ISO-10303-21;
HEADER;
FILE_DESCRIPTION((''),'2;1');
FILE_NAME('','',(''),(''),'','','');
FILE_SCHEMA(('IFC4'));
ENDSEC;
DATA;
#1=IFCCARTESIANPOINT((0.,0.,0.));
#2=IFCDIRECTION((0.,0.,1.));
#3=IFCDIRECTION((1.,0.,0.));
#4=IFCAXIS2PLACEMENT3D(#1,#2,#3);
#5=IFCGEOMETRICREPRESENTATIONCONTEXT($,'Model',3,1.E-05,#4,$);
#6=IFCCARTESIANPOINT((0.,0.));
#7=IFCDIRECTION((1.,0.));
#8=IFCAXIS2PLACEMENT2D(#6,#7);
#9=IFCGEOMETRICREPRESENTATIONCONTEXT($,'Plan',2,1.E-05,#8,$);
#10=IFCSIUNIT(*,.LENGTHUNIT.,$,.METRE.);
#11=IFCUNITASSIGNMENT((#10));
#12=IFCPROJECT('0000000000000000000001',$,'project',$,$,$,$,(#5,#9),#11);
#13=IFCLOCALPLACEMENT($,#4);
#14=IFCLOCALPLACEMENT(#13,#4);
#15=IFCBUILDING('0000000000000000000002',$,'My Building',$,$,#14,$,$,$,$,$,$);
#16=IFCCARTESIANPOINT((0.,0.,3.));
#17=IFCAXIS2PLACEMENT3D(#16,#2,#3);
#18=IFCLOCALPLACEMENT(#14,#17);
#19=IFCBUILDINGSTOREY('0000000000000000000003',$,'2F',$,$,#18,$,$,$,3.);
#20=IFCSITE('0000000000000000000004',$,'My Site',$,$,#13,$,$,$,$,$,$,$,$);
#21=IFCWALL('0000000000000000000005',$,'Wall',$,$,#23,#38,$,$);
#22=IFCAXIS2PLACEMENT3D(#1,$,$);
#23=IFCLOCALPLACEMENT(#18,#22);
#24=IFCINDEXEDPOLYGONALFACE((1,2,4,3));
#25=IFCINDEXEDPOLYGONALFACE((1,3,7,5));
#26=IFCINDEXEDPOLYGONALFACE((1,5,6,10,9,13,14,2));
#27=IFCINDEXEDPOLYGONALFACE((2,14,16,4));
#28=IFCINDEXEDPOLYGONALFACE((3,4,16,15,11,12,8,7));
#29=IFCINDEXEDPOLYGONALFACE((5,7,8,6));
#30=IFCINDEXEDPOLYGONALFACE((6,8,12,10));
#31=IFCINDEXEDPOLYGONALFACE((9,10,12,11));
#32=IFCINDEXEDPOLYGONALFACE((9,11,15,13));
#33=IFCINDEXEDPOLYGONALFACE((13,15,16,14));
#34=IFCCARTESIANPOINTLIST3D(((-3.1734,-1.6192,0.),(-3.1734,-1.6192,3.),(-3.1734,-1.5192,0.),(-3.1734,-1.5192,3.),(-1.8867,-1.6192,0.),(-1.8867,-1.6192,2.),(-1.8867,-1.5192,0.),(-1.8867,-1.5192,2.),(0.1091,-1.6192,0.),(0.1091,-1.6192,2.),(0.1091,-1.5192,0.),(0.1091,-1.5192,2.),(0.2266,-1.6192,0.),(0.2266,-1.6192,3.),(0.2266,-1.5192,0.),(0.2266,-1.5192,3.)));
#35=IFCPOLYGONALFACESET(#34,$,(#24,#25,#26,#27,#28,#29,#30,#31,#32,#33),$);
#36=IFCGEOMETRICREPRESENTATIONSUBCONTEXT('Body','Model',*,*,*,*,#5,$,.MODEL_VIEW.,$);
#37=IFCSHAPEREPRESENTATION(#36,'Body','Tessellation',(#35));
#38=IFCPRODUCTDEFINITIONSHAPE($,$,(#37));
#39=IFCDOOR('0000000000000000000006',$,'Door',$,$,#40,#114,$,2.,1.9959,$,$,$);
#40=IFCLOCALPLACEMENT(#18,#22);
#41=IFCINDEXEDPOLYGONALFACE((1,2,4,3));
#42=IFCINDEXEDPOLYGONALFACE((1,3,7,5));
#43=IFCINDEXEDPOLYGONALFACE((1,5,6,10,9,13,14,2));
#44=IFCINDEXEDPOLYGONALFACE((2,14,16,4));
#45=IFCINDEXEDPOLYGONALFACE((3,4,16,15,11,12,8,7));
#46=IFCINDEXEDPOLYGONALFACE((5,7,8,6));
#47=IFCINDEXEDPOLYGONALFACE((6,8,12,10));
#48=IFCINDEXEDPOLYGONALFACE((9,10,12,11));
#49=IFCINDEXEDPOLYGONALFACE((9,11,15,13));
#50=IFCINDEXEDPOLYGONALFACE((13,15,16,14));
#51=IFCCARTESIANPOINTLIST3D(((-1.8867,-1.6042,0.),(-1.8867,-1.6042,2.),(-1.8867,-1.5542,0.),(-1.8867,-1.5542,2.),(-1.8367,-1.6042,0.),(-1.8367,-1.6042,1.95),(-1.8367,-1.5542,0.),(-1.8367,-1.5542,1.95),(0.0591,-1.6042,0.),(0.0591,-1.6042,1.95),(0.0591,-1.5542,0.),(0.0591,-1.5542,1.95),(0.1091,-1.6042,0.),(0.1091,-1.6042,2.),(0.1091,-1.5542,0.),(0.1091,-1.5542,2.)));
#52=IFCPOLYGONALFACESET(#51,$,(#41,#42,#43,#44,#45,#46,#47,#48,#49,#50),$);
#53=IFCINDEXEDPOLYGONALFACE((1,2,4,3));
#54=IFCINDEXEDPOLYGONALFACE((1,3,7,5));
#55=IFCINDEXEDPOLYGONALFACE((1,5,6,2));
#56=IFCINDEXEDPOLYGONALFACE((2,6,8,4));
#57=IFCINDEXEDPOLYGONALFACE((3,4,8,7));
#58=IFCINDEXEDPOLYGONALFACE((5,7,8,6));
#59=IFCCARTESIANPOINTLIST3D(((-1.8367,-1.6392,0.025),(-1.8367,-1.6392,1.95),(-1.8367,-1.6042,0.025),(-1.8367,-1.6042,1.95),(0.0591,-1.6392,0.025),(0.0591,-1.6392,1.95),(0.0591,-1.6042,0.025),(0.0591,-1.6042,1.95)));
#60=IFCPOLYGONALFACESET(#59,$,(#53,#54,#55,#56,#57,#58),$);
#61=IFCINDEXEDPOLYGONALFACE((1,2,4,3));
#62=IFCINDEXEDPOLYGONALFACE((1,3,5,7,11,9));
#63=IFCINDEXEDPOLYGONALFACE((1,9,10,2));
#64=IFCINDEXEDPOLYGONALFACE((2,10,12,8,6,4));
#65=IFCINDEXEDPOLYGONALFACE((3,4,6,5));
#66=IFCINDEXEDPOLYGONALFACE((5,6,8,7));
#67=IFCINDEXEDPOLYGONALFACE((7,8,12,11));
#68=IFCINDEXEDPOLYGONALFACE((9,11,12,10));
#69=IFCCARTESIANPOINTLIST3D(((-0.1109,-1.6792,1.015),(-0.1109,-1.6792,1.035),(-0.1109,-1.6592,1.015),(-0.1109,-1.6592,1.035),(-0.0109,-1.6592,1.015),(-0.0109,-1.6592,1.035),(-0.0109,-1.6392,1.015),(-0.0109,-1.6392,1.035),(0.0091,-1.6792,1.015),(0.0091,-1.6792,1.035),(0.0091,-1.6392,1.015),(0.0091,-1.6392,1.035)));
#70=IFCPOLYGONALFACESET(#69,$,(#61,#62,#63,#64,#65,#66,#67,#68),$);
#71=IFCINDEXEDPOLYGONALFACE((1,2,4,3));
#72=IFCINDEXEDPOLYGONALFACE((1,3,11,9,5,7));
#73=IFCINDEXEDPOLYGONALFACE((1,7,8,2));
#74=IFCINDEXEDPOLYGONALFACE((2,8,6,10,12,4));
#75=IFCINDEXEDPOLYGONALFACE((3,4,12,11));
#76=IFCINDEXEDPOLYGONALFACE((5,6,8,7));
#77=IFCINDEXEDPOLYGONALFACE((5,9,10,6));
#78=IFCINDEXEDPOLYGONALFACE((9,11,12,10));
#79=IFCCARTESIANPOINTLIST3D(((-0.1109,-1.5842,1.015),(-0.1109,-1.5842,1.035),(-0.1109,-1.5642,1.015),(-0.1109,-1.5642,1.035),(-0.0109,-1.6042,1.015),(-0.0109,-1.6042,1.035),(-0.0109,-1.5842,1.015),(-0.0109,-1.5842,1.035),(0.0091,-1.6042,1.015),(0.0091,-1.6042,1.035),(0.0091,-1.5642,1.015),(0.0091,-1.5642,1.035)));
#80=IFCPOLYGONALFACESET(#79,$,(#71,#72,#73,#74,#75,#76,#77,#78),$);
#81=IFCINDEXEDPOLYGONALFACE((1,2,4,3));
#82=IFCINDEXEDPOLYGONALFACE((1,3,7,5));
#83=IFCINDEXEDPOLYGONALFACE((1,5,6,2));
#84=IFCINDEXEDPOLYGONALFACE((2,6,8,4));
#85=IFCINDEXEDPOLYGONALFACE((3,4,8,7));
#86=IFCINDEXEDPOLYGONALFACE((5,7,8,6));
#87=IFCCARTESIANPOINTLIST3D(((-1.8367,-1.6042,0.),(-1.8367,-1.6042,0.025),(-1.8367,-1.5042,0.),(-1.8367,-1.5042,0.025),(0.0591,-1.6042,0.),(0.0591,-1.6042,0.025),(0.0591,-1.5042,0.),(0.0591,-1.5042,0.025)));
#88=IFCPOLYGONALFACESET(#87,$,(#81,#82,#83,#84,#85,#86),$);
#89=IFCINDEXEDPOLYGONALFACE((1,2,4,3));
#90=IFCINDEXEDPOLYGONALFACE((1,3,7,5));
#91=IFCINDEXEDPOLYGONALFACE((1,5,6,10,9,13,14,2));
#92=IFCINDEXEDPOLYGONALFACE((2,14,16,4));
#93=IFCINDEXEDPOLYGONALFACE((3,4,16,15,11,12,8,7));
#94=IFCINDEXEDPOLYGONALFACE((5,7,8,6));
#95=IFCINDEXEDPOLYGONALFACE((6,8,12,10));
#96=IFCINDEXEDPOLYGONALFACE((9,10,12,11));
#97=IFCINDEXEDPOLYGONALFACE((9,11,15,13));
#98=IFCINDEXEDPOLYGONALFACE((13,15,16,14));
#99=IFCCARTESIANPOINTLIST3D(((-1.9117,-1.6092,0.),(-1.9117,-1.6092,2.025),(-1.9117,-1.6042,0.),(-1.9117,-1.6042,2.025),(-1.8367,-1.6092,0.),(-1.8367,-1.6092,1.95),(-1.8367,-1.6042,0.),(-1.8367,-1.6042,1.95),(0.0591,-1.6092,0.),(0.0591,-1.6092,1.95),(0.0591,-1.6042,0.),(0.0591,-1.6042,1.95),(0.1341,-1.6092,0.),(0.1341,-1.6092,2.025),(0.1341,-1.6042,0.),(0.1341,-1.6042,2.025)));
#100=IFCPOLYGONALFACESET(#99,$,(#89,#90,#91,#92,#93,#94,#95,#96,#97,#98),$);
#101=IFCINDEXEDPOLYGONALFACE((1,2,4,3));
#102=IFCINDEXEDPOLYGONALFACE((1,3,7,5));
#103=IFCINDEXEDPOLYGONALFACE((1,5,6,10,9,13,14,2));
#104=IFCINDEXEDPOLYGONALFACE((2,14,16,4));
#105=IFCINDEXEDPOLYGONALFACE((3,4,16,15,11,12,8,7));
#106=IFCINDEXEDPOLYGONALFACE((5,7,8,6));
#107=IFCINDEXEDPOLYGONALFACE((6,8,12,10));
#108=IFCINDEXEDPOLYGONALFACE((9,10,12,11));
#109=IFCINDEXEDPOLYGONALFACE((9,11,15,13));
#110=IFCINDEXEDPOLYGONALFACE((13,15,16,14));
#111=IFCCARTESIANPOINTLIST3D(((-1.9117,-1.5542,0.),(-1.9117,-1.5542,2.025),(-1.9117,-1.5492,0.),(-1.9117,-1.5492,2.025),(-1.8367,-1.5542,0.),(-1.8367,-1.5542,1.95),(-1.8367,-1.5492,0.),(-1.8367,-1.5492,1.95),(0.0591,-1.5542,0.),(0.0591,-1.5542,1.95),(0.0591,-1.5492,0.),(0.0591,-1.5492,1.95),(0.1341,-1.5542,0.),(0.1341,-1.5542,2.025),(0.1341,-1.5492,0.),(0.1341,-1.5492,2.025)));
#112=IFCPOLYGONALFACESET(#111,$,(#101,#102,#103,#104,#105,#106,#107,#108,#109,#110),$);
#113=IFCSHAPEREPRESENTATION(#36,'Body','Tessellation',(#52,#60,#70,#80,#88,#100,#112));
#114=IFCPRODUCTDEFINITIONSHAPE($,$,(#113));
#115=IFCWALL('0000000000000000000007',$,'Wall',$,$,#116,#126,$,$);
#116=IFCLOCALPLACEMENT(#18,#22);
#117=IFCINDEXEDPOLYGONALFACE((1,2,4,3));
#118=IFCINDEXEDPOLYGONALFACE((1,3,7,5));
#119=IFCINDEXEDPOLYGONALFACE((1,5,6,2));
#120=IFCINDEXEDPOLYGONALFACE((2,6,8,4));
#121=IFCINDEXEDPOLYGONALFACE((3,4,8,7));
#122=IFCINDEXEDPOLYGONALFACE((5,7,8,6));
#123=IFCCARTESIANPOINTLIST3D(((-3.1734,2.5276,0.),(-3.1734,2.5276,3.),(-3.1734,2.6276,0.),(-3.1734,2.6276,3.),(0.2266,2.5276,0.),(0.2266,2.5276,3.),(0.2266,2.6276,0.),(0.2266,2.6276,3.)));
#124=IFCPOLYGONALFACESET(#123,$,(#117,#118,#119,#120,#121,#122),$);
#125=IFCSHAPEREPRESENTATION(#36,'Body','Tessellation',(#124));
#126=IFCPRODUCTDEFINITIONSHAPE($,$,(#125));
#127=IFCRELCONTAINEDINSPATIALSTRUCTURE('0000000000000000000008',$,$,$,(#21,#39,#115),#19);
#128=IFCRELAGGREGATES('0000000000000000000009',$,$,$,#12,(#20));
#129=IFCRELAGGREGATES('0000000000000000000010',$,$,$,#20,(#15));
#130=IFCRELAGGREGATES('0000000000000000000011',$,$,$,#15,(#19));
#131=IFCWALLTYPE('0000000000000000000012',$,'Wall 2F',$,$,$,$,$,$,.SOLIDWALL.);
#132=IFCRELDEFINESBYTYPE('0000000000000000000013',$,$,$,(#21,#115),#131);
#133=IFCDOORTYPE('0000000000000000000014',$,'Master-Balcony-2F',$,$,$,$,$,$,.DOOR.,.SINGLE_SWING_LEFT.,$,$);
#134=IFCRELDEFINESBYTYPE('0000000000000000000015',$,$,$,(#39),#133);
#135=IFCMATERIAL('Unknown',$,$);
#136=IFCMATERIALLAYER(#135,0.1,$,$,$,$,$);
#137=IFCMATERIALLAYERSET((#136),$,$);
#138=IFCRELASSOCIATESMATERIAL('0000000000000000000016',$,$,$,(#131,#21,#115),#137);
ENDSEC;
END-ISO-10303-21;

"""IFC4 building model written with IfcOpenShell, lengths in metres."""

from ifc_helpers import new_model, entity, si_unit, frame, origin_with_axes, origin_2d_with_axis, place, context, subcontext, project, spatial, polyline, line, indexed_curve, outline, extrude, shape, source, transform, mapped, material, layer, layer_set, layer_usage, type_object, type_shapes, element, fill, save


model = new_model("IFC4")

# Units and contexts
model_context = context("Model", 3, precision=1e-05, world=origin_with_axes())
plan_context = context("Plan", 2, precision=1e-05, world=origin_2d_with_axis())
body_context_1 = subcontext(model_context, "Body", "Model", "MODEL_VIEW")
body_context_2 = subcontext(plan_context, "Body", "Plan", "PLAN_VIEW")
ifc_project = project(units=[si_unit("LENGTHUNIT", "METRE")], contexts=[model_context, plan_context])

# Site, building, storey
site_placement = place(None, origin_with_axes())
site = spatial("IfcSite", under=ifc_project, at=site_placement, Name="My Site")
building_placement = place(site_placement, origin_with_axes())
building = spatial("IfcBuilding", under=site, at=building_placement, Name="My Building")
storey_placement = place(building_placement, frame((0.0, 0.0, 3.0), z_axis=(0.0, 0.0, 1.0), x_axis=(1.0, 0.0, 0.0)))
storey = spatial("IfcBuildingStorey", under=building, at=storey_placement, Name="2F", Elevation=3.0)

# Shared definitions
ifc_material = material(Name="Unknown")

# Shared definitions
ifc_layer_1 = layer(ifc_material, 0.1)
ifc_layer_set_1 = layer_set([ifc_layer_1])
wall_type = type_object("IfcWallType", Name="Wall 2F", PredefinedType="SOLIDWALL", material=ifc_layer_set_1)

# Wall, opening, door
ifc_layer_usage_1 = layer_usage(ifc_layer_set_1, "AXIS2", "POSITIVE", 0.0)
wall_1_placement = place(storey_placement, frame((-3.1734, -1.6192, 0.0), z_axis=(0.0, 0.0, 1.0), x_axis=(1.0, 0.0, 0.0)))
wall_1 = element("IfcWall", 1, at=wall_1_placement, inside=storey, type_object=wall_type, material=ifc_layer_usage_1, Name="Wall", context=body_context_1, shape_type="SweptSolid", body=[
    extrude(outline(polyline([(0.0, 0.0), (3.4, 0.0), (3.4, 0.1), (0.0, 0.1), (0.0, 0.0)])), origin_with_axes(), (0.0, 0.0, 1.0), 3.0),
])
opening_1_placement = place(wall_1_placement, frame((1.2866, 0.015, 0.0), z_axis=(0.0, 0.0, 1.0), x_axis=(1.0, 0.0, 0.0)))
opening_1 = element("IfcOpeningElement", 2, at=opening_1_placement, cuts=wall_1, PredefinedType="OPENING", context=body_context_1, shape_type="SweptSolid", body=[
    extrude(outline(polyline([(0.0, 0.0), (1.9959, 0.0), (1.9959, 2.0), (0.0, 2.0), (0.0, 0.0)])), frame((0.0, -0.6, 0.0), z_axis=(0.0, -1.0, 0.0), x_axis=(1.0, 0.0, 0.0)), (0.0, 0.0, -1.0), 1.2),
])
door_type_1 = type_object("IfcDoorType", Name="Master-Balcony-2F", OperationType="SINGLE_SWING_LEFT", PredefinedType="DOOR")
shared_shape_1 = source(origin_with_axes(), body_context_1, "Body", "SweptSolid", [
    extrude(outline(indexed_curve([(0.0, 0.0), (0.0, 2.0), (1.9959, 2.0), (1.9959, 0.0), (1.9459, 0.0), (1.9459, 1.95), (0.05, 1.95), (0.05, 0.0)], segments=[line(1, 2, 3, 4, 5, 6, 7, 8, 1)])), frame((0.0, 0.0, 0.0), z_axis=(0.0, -1.0, 0.0), x_axis=(1.0, 0.0, 0.0)), (0.0, 0.0, -1.0), 0.05),
    extrude(outline(indexed_curve([(0.0, 0.0), (1.8959, 0.0), (1.8959, 0.035), (0.0, 0.035)], segments=[line(1, 2, 3, 4, 1)])), frame((0.05, -0.035, 0.025), z_axis=(0.0, 0.0, 1.0), x_axis=(1.0, 0.0, 0.0)), (0.0, 0.0, 1.0), 1.925),
    extrude(outline(indexed_curve([(0.0, 0.0), (0.0, -0.04), (-0.12, -0.04), (-0.12, -0.02), (-0.02, -0.02), (-0.02, 0.0)], segments=[line(1, 2, 3, 4, 5, 6, 1)])), frame((1.8959, -0.035, 1.015), z_axis=(0.0, 0.0, 1.0), x_axis=(1.0, 0.0, 0.0)), (0.0, 0.0, 1.0), 0.02),
    extrude(outline(indexed_curve([(0.0, 0.0), (0.0, 0.04), (-0.12, 0.04), (-0.12, 0.02), (-0.02, 0.02), (-0.02, 0.0)], segments=[line(1, 2, 3, 4, 5, 6, 1)])), frame((1.8959, 0.0, 1.015), z_axis=(0.0, 0.0, 1.0), x_axis=(1.0, 0.0, 0.0)), (0.0, 0.0, 1.0), 0.02),
    extrude(outline(indexed_curve([(0.0, 0.0), (1.8959, 0.0), (1.8959, 0.1), (0.0, 0.1)], segments=[line(1, 2, 3, 4, 1)])), frame((0.05, 0.0, 0.0), z_axis=(0.0, 0.0, 1.0), x_axis=(1.0, 0.0, 0.0)), (0.0, 0.0, 1.0), 0.025),
    extrude(outline(indexed_curve([(0.0, 0.0), (0.0, 2.025), (2.0459, 2.025), (2.0459, 0.0), (1.9709, 0.0), (1.9709, 1.95), (0.075, 1.95), (0.075, 0.0)], segments=[line(1, 2, 3, 4, 5, 6, 7, 8, 1)])), frame((-0.025, -0.005, 0.0), z_axis=(0.0, -1.0, 0.0), x_axis=(1.0, 0.0, 0.0)), (0.0, 0.0, -1.0), 0.005),
    extrude(outline(indexed_curve([(0.0, 0.0), (0.0, 2.025), (2.0459, 2.025), (2.0459, 0.0), (1.9709, 0.0), (1.9709, 1.95), (0.075, 1.95), (0.075, 0.0)], segments=[line(1, 2, 3, 4, 5, 6, 7, 8, 1)])), frame((-0.025, 0.05, 0.0), z_axis=(0.0, -1.0, 0.0), x_axis=(1.0, 0.0, 0.0)), (0.0, 0.0, -1.0), 0.005),
])
shared_shape_2 = source(origin_with_axes(), body_context_2, "Body", "Curve2D", [
    entity("IfcIndexedPolyCurve", entity("IfcCartesianPointList2D", [[0.0, 0.0], [0.05, 0.0], [0.05, 0.05], [0.0, 0.05]]), [entity("IfcLineIndex", [1, 2, 3, 4, 1])]),
    entity("IfcIndexedPolyCurve", entity("IfcCartesianPointList2D", [[1.9959, 0.0], [1.9459, 0.0], [1.9459, 0.05], [1.9959, 0.05]]), [entity("IfcLineIndex", [1, 2, 3, 4, 1])]),
    entity("IfcIndexedPolyCurve", entity("IfcCartesianPointList2D", [[-0.8979, -0.035], [0.9979, -0.035], [0.9979, 0.0], [-0.8979, 0.0]]), [entity("IfcLineIndex", [1, 2, 3, 4, 1])]),
])
type_shapes(door_type_1, [shared_shape_1, shared_shape_2])
door_1_placement = place(storey_placement, frame((-1.8867, -1.6042, 0.0), z_axis=(0.0, 0.0, 1.0), x_axis=(1.0, 0.0, 0.0)))
door_1 = element("IfcDoor", 3, at=door_1_placement, inside=storey, type_object=door_type_1, Name="Door", OverallHeight=2.0, OverallWidth=1.9959, shapes=[
    shape(body_context_1, "Body", "MappedRepresentation", [mapped(shared_shape_1, transform((0.0, 0.0, 0.0), x_axis=(1.0, 0.0, 0.0), y_axis=(0.0, 1.0, 0.0), z_axis=(0.0, 0.0, 1.0), scale=1.0))]),
    shape(body_context_2, "Body", "MappedRepresentation", [mapped(shared_shape_2, transform((0.0, 0.0, 0.0), x_axis=(1.0, 0.0, 0.0), y_axis=(0.0, 1.0, 0.0), z_axis=(0.0, 0.0, 1.0), scale=1.0))]),
])
fill(opening_1, door_1)

# Wall
ifc_layer_usage_2 = layer_usage(ifc_layer_set_1, "AXIS2", "POSITIVE", 0.0)
wall_2_placement = place(storey_placement, frame((0.2266, 2.6276, 0.0), z_axis=(0.0, 0.0, 1.0), x_axis=(-1.0, 0.0, 0.0)))
element("IfcWall", 4, at=wall_2_placement, inside=storey, type_object=wall_type, material=ifc_layer_usage_2, Name="Wall", context=body_context_1, shape_type="SweptSolid", body=[
    extrude(outline(polyline([(0.0, 0.0), (3.4, 0.0), (3.4, 0.1), (0.0, 0.1), (0.0, 0.0)])), origin_with_axes(), (0.0, 0.0, 1.0), 3.0),
])

save(model, "model.ifc")
